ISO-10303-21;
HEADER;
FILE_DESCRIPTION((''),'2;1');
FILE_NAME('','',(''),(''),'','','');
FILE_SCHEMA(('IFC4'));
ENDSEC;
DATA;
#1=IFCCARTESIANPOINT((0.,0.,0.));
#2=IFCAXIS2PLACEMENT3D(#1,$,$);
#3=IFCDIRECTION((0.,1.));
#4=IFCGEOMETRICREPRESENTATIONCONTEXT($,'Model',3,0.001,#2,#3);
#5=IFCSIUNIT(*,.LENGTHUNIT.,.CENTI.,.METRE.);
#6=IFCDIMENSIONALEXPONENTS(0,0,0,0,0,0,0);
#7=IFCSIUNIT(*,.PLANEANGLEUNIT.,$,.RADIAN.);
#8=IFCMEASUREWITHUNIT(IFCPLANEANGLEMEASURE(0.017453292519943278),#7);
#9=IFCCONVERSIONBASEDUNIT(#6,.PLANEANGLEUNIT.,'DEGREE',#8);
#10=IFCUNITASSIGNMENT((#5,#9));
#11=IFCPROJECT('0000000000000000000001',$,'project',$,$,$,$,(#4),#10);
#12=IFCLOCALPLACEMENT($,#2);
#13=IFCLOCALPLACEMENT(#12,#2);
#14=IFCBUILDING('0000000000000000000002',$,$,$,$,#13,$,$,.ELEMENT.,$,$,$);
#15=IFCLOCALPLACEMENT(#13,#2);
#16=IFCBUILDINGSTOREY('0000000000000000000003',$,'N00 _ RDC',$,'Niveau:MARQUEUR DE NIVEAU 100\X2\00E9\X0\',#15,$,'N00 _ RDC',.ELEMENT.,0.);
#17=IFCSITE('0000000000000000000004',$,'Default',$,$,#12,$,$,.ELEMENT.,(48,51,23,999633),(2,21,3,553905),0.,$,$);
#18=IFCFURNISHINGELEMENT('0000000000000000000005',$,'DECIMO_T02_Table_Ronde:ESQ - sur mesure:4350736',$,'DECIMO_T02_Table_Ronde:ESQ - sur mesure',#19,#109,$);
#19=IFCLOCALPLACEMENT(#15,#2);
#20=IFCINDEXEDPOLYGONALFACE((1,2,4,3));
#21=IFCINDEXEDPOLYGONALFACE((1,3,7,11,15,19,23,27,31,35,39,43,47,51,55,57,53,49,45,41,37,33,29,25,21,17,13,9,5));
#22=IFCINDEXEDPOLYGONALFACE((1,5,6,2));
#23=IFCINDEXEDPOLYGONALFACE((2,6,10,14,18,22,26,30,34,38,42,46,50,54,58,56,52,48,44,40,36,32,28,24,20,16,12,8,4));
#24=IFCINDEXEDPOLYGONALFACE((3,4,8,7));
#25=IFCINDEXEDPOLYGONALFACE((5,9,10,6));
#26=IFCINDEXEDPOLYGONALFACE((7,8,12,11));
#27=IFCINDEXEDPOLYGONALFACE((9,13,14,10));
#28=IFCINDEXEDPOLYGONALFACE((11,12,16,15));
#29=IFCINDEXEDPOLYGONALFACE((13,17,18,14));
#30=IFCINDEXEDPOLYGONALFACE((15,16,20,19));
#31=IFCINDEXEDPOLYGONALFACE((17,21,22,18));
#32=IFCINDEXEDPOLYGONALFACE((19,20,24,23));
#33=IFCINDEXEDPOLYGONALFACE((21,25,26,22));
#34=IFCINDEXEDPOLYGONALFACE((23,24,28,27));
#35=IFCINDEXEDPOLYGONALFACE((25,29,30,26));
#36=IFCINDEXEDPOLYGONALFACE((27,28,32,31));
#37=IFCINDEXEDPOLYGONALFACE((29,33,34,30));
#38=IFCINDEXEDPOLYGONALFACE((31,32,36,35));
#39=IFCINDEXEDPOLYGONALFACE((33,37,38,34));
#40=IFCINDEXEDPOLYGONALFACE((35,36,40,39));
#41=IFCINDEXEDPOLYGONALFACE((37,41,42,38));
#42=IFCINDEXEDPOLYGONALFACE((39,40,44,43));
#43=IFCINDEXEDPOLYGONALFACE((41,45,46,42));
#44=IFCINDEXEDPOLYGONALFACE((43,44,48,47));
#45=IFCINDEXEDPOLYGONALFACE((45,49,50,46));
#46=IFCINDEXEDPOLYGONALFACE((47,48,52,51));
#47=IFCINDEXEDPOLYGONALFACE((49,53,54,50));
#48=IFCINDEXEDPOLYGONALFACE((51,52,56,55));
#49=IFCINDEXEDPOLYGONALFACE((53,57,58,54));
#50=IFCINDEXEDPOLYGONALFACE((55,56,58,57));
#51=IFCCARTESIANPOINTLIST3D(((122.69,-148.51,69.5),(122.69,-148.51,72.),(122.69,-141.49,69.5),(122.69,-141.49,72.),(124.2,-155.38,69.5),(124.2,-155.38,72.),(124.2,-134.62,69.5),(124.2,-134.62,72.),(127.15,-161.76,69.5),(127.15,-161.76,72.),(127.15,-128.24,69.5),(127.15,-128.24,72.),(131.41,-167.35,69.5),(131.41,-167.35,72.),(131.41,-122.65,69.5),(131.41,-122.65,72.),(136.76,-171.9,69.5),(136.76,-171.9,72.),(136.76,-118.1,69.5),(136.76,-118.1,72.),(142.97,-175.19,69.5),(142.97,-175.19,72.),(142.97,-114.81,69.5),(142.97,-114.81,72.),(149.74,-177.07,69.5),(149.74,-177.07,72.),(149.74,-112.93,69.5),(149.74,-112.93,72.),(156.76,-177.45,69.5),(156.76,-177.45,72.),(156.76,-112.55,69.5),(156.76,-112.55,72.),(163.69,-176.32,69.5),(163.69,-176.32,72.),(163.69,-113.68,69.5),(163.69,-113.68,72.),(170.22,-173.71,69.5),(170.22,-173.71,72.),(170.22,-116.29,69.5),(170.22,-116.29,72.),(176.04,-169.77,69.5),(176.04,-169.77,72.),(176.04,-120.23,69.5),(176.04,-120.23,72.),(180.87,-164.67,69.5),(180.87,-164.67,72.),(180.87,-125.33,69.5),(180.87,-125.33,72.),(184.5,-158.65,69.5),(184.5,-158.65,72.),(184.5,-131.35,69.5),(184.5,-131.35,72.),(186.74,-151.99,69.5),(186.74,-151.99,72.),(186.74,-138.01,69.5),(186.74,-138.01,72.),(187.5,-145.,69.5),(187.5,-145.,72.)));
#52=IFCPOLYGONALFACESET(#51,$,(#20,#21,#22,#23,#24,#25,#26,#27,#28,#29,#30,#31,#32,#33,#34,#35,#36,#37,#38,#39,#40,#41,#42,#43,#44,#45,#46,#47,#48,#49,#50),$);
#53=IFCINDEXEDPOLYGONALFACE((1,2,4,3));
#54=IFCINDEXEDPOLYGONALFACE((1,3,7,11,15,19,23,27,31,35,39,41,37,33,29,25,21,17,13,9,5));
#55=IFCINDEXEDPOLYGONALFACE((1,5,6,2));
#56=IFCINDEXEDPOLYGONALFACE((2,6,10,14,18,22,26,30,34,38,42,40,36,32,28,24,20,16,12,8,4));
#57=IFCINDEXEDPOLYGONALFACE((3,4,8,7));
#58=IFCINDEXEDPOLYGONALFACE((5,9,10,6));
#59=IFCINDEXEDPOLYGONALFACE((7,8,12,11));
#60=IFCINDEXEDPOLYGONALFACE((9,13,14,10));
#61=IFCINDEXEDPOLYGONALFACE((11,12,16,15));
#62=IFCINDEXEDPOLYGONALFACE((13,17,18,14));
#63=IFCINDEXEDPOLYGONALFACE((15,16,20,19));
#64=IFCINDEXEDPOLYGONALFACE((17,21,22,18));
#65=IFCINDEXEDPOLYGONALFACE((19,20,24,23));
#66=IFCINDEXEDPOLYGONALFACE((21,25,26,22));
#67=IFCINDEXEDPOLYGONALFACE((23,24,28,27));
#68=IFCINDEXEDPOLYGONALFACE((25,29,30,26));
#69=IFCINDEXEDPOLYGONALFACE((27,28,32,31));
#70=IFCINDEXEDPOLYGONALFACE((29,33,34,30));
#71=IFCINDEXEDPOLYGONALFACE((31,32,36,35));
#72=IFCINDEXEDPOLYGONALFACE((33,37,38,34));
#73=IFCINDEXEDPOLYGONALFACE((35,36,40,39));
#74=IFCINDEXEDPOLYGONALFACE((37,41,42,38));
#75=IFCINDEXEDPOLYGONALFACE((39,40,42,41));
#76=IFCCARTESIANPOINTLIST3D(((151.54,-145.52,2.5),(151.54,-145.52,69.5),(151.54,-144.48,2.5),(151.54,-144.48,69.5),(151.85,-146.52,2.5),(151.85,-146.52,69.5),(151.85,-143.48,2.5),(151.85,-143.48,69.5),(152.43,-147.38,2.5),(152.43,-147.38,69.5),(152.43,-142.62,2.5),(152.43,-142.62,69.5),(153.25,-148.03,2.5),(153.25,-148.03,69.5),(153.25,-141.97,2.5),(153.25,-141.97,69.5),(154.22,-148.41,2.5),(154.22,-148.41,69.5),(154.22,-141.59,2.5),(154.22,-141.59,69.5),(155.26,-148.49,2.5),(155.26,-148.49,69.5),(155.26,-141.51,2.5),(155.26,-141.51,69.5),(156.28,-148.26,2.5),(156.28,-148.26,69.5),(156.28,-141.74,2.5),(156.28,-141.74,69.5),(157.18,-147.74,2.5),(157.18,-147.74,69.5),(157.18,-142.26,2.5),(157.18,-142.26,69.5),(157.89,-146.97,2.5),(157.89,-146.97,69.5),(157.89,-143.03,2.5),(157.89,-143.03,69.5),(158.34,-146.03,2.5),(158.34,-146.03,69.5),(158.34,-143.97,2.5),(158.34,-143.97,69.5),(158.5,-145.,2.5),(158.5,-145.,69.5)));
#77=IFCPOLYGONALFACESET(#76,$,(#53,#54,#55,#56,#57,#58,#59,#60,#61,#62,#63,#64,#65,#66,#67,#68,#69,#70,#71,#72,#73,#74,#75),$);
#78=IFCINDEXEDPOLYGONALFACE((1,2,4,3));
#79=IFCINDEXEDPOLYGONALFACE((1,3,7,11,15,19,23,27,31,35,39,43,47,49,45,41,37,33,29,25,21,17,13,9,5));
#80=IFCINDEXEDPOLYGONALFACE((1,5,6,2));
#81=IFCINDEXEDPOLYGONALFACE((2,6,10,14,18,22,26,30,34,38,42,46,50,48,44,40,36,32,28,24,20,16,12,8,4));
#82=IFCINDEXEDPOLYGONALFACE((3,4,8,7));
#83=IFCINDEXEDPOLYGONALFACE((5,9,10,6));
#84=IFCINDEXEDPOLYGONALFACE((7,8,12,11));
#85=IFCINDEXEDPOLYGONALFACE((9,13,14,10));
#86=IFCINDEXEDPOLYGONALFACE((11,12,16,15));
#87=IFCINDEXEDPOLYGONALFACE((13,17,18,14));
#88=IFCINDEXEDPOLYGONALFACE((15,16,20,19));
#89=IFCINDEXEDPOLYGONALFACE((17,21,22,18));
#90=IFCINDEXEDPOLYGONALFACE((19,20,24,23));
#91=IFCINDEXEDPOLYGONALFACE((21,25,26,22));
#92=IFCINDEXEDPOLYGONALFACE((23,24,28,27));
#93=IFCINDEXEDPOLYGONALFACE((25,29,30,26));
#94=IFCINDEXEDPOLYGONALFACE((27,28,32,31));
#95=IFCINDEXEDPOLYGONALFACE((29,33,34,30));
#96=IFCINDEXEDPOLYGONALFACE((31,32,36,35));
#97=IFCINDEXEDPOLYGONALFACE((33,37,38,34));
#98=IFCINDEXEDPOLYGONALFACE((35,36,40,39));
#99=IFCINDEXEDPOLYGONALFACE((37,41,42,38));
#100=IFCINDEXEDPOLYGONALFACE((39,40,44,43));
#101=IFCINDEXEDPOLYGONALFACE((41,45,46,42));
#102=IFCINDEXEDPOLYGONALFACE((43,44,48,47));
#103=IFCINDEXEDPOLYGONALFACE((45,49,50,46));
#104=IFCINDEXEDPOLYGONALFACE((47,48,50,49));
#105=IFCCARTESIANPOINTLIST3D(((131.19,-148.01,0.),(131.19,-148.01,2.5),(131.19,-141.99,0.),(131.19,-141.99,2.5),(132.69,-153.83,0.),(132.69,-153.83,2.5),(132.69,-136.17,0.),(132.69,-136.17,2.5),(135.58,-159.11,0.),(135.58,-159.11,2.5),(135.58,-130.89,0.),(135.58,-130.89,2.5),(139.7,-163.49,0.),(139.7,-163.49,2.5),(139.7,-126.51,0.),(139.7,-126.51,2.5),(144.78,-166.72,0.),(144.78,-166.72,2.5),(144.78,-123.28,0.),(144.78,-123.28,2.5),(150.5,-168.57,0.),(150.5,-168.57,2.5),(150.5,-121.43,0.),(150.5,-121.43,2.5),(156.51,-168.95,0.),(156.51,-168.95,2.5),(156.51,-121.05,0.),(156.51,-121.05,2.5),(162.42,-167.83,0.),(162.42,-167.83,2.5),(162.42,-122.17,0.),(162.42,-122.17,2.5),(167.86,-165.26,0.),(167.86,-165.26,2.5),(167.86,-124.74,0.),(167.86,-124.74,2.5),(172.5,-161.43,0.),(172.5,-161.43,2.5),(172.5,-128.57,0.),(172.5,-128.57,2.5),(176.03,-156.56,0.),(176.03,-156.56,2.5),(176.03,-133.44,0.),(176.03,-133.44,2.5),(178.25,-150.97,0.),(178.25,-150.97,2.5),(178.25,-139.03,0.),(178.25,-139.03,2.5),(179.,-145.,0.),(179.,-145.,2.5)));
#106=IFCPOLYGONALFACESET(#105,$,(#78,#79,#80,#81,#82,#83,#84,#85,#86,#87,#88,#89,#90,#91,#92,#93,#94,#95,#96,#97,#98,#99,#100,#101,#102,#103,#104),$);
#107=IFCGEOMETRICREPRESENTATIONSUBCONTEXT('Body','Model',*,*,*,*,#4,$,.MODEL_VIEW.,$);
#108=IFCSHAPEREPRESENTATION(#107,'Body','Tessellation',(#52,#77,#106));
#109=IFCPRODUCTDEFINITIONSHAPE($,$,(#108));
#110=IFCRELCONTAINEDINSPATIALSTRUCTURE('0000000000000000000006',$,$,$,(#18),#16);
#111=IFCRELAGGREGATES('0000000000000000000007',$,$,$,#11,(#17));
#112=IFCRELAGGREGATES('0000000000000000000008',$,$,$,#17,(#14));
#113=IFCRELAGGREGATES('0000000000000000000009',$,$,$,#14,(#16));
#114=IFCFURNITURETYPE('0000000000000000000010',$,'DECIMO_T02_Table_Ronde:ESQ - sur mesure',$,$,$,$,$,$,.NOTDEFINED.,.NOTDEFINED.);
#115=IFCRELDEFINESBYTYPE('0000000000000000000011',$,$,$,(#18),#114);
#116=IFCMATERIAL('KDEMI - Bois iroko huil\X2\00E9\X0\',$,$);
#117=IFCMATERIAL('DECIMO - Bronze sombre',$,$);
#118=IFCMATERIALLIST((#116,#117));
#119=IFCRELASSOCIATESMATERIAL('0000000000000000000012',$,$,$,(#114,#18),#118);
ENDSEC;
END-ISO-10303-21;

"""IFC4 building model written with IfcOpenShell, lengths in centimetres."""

from ifc_helpers import new_model, entity, si_unit, converted_unit, direction, frame, frame_2d, origin, place, context, subcontext, project, spatial, circle, extrude, source, transform, mapped, material, material_list, type_object, type_shapes, element, save


model = new_model("IFC4")

# Units and contexts
model_context = context("Model", 3, precision=0.001, world=origin(), true_north=direction((0.0, 1.0)))
body_context = subcontext(model_context, "Body", "Model", "MODEL_VIEW")
ifc_project = project(units=[si_unit("LENGTHUNIT", "METRE", prefix="CENTI"), converted_unit("PLANEANGLEUNIT", "DEGREE", entity("IfcPlaneAngleMeasure", 0.017453292519943278), si_unit("PLANEANGLEUNIT", "RADIAN"), dimensions=[0, 0, 0, 0, 0, 0, 0])], contexts=[model_context])

# Site, building, storey
site_placement = place(None, origin())
site = spatial("IfcSite", under=ifc_project, at=site_placement, Name="Default", CompositionType="ELEMENT", RefLatitude=(48, 51, 23, 999633), RefLongitude=(2, 21, 3, 553905), RefElevation=0.0)
building_placement = place(site_placement, origin())
building = spatial("IfcBuilding", under=site, at=building_placement, CompositionType="ELEMENT")
storey_placement = place(building_placement, origin())
storey = spatial("IfcBuildingStorey", under=building, at=storey_placement, Name="N00 _ RDC", ObjectType="Niveau:MARQUEUR DE NIVEAU 100é", LongName="N00 _ RDC", CompositionType="ELEMENT", Elevation=0.0)

# Furnishing element
ifc_material_1 = material(Name="KDEMI - Bois iroko huilé")
ifc_material_2 = material(Name="DECIMO - Bronze sombre")
ifc_material_list_1 = material_list([ifc_material_1, ifc_material_2])
furniture_type_1 = type_object("IfcFurnitureType", Name="DECIMO_T02_Table_Ronde:ESQ - sur mesure", AssemblyPlace="NOTDEFINED", material=ifc_material_list_1)
shared_shape_1 = source(origin(), body_context, "Body", "SweptSolid", [
    extrude(circle(Radius=32.5, at=frame_2d((0.0, 0.0), x_axis=(1.0, 0.0))), frame((0.0, 0.0, 69.5)), (0.0, 0.0, 1.0), 2.5),
    extrude(circle(Radius=3.5, at=frame_2d((0.0, 0.0), x_axis=(1.0, 0.0))), frame((0.0, 0.0, 2.5)), (0.0, 0.0, 1.0), 67.0),
    extrude(circle(Radius=24.0, at=frame_2d((0.0, 0.0), x_axis=(1.0, 0.0))), origin(), (0.0, 0.0, 1.0), 2.5),
])
type_shapes(furniture_type_1, [shared_shape_1])
for number, where, name in (
    (1, (155.0, -145.0, 0.0), "DECIMO_T02_Table_Ronde:ESQ - sur mesure:4350736"),
):
    element("IfcFurnishingElement", number, at=place(storey_placement, frame(where)), inside=storey, type_object=furniture_type_1, material=ifc_material_list_1, Name=name, ObjectType="DECIMO_T02_Table_Ronde:ESQ - sur mesure", context=body_context, shape_type="MappedRepresentation", body=[
        mapped(shared_shape_1, transform((0.0, 0.0, 0.0), scale=1.0)),
    ])

save(model, "model.ifc")
